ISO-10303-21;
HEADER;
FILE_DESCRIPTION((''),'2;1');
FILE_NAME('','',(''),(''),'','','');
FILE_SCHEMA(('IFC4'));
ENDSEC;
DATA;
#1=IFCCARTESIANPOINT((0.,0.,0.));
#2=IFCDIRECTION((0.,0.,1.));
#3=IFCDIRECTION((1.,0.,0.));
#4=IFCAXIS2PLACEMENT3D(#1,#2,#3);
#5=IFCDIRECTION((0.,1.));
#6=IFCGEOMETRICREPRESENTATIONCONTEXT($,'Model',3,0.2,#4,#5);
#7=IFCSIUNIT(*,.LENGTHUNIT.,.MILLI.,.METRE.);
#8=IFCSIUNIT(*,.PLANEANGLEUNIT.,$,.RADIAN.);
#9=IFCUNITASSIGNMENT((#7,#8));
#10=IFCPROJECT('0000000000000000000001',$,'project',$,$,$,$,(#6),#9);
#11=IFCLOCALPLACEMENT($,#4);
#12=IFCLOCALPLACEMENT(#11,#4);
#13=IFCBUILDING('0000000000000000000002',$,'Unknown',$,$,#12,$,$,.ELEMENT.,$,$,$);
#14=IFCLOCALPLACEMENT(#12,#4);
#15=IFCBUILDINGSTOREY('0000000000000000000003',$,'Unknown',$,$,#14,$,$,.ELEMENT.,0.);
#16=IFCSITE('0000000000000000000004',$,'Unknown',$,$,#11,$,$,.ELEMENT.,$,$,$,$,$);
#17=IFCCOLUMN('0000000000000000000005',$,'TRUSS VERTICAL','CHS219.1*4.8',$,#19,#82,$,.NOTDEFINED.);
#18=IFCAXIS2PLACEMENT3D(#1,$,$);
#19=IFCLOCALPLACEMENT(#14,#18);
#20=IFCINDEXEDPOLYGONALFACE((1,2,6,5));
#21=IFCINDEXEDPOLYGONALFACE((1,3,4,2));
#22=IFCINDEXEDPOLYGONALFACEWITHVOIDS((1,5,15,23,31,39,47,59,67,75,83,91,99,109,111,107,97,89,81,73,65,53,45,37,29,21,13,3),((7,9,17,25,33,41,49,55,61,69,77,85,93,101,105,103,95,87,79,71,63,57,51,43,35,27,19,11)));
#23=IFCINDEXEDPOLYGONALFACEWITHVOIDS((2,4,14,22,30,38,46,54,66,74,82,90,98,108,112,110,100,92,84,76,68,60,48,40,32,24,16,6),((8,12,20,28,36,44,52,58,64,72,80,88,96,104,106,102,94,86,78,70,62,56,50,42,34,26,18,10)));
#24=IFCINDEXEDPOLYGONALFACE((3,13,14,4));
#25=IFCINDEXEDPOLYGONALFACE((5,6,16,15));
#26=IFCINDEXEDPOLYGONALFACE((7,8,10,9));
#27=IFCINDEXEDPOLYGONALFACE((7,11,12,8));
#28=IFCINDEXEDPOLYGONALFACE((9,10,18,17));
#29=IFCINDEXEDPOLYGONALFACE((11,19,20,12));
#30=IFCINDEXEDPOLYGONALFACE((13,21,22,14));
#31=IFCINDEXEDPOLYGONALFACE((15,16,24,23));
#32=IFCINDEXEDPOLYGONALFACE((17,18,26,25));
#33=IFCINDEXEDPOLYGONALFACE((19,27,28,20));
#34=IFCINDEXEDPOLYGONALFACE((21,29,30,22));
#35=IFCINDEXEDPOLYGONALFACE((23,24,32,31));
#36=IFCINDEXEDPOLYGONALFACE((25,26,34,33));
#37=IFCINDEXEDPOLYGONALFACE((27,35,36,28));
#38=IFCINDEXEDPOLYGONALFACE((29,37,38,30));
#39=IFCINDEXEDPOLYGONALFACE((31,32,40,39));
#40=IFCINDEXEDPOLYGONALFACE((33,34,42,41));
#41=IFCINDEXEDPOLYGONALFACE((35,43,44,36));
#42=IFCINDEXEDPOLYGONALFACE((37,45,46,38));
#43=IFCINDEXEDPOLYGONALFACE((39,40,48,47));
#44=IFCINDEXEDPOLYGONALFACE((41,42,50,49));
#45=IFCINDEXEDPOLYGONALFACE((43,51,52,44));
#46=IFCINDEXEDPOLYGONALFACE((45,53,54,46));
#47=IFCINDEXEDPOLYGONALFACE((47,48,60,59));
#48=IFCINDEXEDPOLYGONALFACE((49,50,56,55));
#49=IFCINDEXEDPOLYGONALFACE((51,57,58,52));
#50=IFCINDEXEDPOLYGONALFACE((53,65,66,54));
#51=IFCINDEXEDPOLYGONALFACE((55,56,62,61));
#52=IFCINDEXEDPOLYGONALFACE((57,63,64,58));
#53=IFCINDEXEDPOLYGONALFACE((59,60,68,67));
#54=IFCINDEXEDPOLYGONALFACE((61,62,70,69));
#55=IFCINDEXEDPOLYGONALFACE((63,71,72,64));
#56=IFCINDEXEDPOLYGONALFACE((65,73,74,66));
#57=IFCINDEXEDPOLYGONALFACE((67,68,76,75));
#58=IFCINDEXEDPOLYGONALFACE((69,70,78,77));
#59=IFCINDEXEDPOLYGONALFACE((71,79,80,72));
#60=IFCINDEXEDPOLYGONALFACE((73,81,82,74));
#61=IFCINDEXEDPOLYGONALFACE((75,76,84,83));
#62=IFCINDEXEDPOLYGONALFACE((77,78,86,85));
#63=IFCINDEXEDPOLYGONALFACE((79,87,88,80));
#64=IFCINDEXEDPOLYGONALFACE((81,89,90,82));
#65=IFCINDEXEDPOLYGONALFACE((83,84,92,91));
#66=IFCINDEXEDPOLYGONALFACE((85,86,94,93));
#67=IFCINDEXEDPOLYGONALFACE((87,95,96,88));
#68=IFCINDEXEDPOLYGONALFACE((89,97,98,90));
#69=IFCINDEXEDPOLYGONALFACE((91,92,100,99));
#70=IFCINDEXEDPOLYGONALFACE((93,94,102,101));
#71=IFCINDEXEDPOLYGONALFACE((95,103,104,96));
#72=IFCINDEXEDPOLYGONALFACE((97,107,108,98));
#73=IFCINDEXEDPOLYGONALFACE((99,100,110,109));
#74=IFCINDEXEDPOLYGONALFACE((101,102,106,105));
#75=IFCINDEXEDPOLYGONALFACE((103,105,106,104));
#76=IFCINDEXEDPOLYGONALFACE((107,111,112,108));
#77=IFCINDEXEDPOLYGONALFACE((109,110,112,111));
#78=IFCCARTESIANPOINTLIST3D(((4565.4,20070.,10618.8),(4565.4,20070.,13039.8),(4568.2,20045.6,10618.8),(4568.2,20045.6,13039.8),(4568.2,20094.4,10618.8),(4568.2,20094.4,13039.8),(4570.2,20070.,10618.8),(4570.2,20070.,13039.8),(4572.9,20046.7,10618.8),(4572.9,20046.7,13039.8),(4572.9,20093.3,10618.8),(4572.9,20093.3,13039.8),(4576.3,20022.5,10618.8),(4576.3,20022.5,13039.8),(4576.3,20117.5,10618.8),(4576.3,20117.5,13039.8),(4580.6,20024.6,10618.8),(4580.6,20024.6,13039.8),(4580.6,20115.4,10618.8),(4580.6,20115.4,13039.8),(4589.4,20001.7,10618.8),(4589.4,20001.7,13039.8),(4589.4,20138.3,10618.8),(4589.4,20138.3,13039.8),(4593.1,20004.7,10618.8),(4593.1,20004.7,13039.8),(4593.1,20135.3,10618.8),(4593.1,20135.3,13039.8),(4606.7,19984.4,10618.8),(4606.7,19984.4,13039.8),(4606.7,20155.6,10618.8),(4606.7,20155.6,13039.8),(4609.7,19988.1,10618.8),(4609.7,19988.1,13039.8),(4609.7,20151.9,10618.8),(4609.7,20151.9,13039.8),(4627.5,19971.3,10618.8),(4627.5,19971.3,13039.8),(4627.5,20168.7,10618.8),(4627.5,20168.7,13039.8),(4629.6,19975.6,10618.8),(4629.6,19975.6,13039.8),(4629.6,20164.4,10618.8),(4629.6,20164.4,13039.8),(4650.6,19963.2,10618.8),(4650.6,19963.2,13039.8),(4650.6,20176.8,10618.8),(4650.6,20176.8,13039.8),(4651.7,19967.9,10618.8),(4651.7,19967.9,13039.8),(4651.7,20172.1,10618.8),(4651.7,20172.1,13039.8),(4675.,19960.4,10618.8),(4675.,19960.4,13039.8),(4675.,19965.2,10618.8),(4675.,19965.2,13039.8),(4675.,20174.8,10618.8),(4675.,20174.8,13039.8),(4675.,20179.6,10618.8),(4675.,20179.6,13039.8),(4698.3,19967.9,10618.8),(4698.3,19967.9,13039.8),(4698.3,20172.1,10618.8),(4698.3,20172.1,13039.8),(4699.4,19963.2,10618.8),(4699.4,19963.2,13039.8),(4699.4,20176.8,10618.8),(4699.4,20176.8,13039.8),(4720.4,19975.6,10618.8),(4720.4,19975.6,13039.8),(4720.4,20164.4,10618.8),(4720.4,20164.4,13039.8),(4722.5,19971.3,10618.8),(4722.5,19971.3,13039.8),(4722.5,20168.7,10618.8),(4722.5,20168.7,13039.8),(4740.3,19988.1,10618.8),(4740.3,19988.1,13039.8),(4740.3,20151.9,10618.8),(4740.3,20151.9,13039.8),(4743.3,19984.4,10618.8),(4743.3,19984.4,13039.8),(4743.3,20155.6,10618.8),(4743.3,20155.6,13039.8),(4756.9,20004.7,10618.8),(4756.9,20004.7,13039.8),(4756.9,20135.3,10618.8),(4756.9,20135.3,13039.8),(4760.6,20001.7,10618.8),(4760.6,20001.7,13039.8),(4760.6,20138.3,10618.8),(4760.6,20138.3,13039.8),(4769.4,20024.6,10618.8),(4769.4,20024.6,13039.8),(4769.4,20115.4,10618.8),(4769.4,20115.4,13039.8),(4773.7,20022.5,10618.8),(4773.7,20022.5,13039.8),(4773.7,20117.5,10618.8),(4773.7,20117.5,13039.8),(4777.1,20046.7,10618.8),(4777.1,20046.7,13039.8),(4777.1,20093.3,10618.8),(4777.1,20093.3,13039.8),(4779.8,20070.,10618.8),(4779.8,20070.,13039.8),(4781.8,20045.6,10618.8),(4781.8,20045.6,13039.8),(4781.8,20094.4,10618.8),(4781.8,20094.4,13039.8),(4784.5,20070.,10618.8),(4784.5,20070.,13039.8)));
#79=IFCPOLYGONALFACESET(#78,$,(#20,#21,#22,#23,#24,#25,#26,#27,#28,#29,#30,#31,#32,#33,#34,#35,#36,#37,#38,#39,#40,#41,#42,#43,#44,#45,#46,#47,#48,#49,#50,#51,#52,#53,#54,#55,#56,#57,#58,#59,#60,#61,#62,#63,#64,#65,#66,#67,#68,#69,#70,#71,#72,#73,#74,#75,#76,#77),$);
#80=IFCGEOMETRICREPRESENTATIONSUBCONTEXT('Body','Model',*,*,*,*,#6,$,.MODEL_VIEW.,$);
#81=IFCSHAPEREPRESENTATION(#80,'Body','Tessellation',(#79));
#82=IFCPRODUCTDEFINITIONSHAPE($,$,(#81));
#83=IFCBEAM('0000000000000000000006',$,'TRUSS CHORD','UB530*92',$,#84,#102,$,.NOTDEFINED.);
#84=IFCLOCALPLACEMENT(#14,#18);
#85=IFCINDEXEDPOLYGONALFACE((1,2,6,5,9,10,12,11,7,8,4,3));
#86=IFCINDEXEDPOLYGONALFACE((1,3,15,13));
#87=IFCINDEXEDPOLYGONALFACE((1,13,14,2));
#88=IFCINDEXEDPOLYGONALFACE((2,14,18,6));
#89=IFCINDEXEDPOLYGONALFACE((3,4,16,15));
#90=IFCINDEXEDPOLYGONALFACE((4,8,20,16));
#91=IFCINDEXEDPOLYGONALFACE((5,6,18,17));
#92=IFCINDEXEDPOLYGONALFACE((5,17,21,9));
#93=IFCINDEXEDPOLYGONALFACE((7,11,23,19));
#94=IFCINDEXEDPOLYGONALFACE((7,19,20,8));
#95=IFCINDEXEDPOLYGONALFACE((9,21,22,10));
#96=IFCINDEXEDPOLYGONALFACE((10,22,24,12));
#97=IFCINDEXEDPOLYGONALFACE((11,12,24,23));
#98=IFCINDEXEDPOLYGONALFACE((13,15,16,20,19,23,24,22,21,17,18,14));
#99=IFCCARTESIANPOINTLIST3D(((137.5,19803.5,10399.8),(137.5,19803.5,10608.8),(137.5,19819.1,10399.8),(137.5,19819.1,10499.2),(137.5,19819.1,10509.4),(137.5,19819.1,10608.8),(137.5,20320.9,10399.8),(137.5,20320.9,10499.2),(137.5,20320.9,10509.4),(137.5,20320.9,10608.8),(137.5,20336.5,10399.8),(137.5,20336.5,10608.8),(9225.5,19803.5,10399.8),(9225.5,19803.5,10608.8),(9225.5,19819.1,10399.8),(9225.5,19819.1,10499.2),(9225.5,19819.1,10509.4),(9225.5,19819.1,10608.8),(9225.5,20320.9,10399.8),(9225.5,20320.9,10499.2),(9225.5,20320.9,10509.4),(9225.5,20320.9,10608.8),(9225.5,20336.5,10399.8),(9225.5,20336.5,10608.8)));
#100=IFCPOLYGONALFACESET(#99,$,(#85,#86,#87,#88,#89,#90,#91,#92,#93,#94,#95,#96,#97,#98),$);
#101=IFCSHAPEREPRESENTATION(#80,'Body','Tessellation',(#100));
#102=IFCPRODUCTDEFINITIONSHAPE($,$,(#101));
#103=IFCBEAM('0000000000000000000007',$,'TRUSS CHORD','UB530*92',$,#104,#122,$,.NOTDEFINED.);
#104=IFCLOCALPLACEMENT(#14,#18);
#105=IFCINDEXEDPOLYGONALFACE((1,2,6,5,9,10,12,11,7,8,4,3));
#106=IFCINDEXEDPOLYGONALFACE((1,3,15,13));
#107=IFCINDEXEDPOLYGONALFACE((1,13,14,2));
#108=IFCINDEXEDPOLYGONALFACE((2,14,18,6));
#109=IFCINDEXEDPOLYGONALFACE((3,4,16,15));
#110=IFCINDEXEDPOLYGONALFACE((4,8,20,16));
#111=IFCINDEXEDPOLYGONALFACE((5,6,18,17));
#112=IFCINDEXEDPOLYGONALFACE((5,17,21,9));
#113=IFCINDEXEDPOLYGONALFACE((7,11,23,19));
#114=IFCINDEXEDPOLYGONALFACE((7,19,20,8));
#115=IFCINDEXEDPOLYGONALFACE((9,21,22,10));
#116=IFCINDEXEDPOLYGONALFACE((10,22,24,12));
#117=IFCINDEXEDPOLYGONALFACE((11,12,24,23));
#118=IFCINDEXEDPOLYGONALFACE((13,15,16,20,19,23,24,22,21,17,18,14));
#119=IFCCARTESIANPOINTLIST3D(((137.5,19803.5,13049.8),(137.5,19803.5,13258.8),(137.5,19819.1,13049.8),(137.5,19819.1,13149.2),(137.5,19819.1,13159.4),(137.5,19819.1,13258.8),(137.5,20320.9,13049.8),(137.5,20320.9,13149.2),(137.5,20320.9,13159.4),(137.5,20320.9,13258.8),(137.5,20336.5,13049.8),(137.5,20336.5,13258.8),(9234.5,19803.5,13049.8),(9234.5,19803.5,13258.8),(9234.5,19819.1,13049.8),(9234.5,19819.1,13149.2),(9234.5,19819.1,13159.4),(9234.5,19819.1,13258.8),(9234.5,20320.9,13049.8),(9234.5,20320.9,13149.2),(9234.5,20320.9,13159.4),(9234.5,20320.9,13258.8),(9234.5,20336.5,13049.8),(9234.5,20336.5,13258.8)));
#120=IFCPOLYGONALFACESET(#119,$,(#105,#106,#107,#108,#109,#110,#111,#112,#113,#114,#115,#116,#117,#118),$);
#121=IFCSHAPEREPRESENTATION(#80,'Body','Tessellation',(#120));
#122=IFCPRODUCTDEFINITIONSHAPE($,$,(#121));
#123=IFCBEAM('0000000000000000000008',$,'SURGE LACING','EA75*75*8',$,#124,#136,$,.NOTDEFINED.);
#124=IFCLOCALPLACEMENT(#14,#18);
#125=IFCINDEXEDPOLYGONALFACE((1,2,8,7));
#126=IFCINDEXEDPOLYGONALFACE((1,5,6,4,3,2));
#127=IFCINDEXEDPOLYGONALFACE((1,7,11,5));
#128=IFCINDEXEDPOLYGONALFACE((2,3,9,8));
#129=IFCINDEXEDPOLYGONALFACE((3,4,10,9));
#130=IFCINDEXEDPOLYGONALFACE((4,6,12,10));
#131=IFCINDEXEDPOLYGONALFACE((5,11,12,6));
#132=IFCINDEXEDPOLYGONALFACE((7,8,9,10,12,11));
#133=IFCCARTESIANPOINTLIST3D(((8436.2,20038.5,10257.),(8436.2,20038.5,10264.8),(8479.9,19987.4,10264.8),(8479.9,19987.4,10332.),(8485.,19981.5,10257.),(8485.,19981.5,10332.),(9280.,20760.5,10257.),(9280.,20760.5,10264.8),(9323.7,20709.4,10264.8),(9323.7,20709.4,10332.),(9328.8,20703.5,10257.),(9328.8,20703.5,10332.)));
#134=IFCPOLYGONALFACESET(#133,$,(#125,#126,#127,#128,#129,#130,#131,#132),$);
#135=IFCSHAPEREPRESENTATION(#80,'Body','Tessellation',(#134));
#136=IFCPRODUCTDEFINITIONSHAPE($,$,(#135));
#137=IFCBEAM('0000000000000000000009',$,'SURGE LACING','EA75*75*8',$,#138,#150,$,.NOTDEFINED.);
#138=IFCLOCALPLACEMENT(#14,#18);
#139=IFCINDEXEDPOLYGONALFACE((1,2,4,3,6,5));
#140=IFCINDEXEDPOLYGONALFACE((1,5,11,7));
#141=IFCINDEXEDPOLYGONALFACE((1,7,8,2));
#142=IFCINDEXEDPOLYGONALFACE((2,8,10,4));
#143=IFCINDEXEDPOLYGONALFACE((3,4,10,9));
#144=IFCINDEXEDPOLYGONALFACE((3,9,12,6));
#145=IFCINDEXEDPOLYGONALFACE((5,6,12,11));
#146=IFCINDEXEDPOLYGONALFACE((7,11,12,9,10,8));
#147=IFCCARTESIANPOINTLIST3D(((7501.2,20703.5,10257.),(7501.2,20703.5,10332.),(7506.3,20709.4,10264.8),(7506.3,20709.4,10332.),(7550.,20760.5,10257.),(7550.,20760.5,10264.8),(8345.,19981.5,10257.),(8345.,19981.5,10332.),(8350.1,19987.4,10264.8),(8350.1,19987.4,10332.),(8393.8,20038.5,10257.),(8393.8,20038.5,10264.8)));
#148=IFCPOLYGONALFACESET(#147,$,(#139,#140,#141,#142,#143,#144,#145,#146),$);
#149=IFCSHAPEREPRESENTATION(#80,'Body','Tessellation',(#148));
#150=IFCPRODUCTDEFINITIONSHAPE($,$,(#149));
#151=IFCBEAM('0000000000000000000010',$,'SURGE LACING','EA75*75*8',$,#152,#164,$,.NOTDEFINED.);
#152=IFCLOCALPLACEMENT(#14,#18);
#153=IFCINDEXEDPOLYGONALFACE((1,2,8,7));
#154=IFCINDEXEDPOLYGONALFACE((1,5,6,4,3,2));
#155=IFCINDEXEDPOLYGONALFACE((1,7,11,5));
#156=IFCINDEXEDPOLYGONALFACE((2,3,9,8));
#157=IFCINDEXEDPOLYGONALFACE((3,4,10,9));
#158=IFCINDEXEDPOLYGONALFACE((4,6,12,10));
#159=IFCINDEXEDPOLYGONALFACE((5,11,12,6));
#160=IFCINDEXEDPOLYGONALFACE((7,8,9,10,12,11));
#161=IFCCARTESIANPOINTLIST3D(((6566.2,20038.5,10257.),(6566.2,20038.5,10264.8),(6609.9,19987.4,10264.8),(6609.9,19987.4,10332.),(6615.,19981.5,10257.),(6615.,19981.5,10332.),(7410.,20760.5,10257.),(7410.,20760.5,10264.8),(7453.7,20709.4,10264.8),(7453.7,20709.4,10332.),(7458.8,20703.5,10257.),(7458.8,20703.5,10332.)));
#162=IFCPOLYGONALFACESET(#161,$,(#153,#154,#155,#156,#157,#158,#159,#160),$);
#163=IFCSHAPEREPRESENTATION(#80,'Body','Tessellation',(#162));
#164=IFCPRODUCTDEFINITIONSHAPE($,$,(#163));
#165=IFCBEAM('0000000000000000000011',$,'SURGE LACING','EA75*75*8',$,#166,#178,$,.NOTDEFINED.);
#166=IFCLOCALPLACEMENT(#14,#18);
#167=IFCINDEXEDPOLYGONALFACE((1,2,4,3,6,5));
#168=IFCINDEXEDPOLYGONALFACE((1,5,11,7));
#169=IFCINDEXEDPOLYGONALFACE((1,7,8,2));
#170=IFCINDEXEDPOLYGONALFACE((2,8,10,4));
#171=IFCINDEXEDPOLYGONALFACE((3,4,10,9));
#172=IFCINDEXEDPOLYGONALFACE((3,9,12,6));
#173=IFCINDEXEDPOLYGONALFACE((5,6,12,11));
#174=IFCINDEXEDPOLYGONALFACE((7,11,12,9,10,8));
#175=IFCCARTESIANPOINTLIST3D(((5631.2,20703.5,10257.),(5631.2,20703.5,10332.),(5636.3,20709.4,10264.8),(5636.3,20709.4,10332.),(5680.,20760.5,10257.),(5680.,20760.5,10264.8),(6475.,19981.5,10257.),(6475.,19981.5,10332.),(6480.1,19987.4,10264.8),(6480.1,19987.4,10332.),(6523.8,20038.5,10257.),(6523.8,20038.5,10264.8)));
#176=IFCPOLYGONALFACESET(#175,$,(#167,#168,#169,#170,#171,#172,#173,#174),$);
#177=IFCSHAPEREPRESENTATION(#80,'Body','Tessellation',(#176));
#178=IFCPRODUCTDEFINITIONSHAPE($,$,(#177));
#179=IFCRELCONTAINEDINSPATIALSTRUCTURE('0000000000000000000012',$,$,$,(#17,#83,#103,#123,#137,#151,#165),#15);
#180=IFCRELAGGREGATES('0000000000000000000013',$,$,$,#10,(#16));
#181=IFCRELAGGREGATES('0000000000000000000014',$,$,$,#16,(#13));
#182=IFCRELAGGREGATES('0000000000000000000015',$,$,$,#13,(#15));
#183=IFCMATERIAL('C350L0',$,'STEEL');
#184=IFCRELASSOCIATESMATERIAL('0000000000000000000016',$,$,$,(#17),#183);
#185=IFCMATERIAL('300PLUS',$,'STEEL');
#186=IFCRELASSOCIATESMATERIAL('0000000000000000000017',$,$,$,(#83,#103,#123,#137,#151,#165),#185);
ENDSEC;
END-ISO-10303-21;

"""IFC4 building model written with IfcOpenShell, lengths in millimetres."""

from ifc_helpers import new_model, si_unit, direction, frame, origin_with_axes, place, context, subcontext, project, spatial, line, indexed_curve, outline, extrude, material, element, save


model = new_model("IFC4")

# Units and contexts
model_context = context("Model", 3, precision=0.2, world=origin_with_axes(), true_north=direction((0.0, 1.0)))
body_context = subcontext(model_context, "Body", "Model", "MODEL_VIEW")
ifc_project = project(units=[si_unit("LENGTHUNIT", "METRE", prefix="MILLI"), si_unit("PLANEANGLEUNIT", "RADIAN")], contexts=[model_context])

# Site, building, storey
site_placement = place(None, origin_with_axes())
site = spatial("IfcSite", under=ifc_project, at=site_placement, Name="Unknown", CompositionType="ELEMENT")
building_placement = place(site_placement, origin_with_axes())
building = spatial("IfcBuilding", under=site, at=building_placement, Name="Unknown", CompositionType="ELEMENT")
storey_placement = place(building_placement, origin_with_axes())
storey = spatial("IfcBuildingStorey", under=building, at=storey_placement, Name="Unknown", CompositionType="ELEMENT", Elevation=0.0)

# Column
ifc_material_1 = material(Name="C350L0", Category="STEEL")
column_placement = place(storey_placement, frame((4675.0, 20070.0, 10618.8), z_axis=(-1.0, 0.0, 0.0), x_axis=(0.0, 0.0, 1.0)))
element("IfcColumn", 1, at=column_placement, inside=storey, material=ifc_material_1, Name="TRUSS VERTICAL", Description="CHS219.1*4.8", PredefinedType="NOTDEFINED", context=body_context, shape_type="SolidModel", body=[
    extrude(outline(indexed_curve([(109.5, 0.0), (106.8, 24.4), (98.7, 47.5), (85.6, 68.3), (68.3, 85.6), (47.5, 98.7), (24.4, 106.8), (0.0, 109.5), (-24.4, 106.8), (-47.5, 98.7), (-68.3, 85.6), (-85.6, 68.3), (-98.7, 47.5), (-106.8, 24.4), (-109.5, 0.0), (-106.8, -24.4), (-98.7, -47.5), (-85.6, -68.3), (-68.3, -85.6), (-47.5, -98.7), (-24.4, -106.8), (0.0, -109.5), (24.4, -106.8), (47.5, -98.7), (68.3, -85.6), (85.6, -68.3), (98.7, -47.5), (106.8, -24.4)], segments=[line(1, 2, 3, 4, 5, 6, 7, 8, 9, 10, 11, 12, 13, 14, 15, 16, 17, 18, 19, 20, 21, 22, 23, 24, 25, 26, 27, 28, 1)]), holes=[indexed_curve([(104.8, 0.0), (102.1, -23.3), (94.4, -45.4), (81.9, -65.3), (65.3, -81.9), (45.4, -94.4), (23.3, -102.1), (0.0, -104.8), (-23.3, -102.1), (-45.4, -94.4), (-65.3, -81.9), (-81.9, -65.3), (-94.4, -45.4), (-102.1, -23.3), (-104.8, 0.0), (-102.1, 23.3), (-94.4, 45.4), (-81.9, 65.3), (-65.3, 81.9), (-45.4, 94.4), (-23.3, 102.1), (0.0, 104.8), (23.3, 102.1), (45.4, 94.4), (65.3, 81.9), (81.9, 65.3), (94.4, 45.4), (102.1, 23.3)], segments=[line(1, 2, 3, 4, 5, 6, 7, 8, 9, 10, 11, 12, 13, 14, 15, 16, 17, 18, 19, 20, 21, 22, 23, 24, 25, 26, 27, 28, 1)])]), frame((0.0, 0.0, 0.0), z_axis=(-1.0, 0.0, 0.0), x_axis=(0.0, 0.0, 1.0)), (0.0, 0.0, -1.0), 2421.0),
])

# Beams
ifc_material_2 = material(Name="300PLUS", Category="STEEL")
beam_1_placement = place(storey_placement, frame((137.5, 20070.0, 10504.3), z_axis=(0.0, 0.0, 1.0), x_axis=(1.0, 0.0, 0.0)))
element("IfcBeam", 2, at=beam_1_placement, inside=storey, material=ifc_material_2, Name="TRUSS CHORD", Description="UB530*92", PredefinedType="NOTDEFINED", context=body_context, shape_type="SolidModel", body=[
    extrude(outline(indexed_curve([(-104.5, -266.5), (104.5, -266.5), (104.5, -250.9), (5.1, -250.9), (5.1, 250.9), (104.5, 250.9), (104.5, 266.5), (-104.5, 266.5), (-104.5, 250.9), (-5.1, 250.9), (-5.1, -250.9), (-104.5, -250.9)], segments=[line(1, 2, 3, 4, 5, 6, 7, 8, 9, 10, 11, 12, 1)])), frame((0.0, 0.0, 0.0), z_axis=(-1.0, 0.0, 0.0), x_axis=(0.0, 0.0, 1.0)), (0.0, 0.0, -1.0), 9088.0),
])
beam_2_placement = place(storey_placement, frame((137.5, 20070.0, 13154.3), z_axis=(0.0, 0.0, 1.0), x_axis=(1.0, 0.0, 0.0)))
element("IfcBeam", 3, at=beam_2_placement, inside=storey, material=ifc_material_2, Name="TRUSS CHORD", Description="UB530*92", PredefinedType="NOTDEFINED", context=body_context, shape_type="SolidModel", body=[
    extrude(outline(indexed_curve([(-104.5, -266.5), (104.5, -266.5), (104.5, -250.9), (5.1, -250.9), (5.1, 250.9), (104.5, 250.9), (104.5, 266.5), (-104.5, 266.5), (-104.5, 250.9), (-5.1, 250.9), (-5.1, -250.9), (-104.5, -250.9)], segments=[line(1, 2, 3, 4, 5, 6, 7, 8, 9, 10, 11, 12, 1)])), frame((0.0, 0.0, 0.0), z_axis=(-1.0, 0.0, 0.0), x_axis=(0.0, 0.0, 1.0)), (0.0, 0.0, -1.0), 9097.0),
])
for number, where, z_axis, x_axis, name in (
    (4, (8460.6, 20010.0, 10294.5), (0.0, 0.0, 1.0), (0.759816, 0.650139, 0.0), "SURGE LACING"),
    (5, (7525.6, 20732.0, 10294.5), (0.0, 0.0, 1.0), (0.759816, -0.650139, 0.0), "SURGE LACING"),
    (6, (6590.6, 20010.0, 10294.5), (0.0, 0.0, 1.0), (0.759816, 0.650139, 0.0), "SURGE LACING"),
    (7, (5655.6, 20732.0, 10294.5), (0.0, 0.0, 1.0), (0.759816, -0.650139, 0.0), "SURGE LACING"),
):
    element("IfcBeam", number, at=place(storey_placement, frame(where, z_axis=z_axis, x_axis=x_axis)), inside=storey, material=ifc_material_2, Name=name, Description="EA75*75*8", PredefinedType="NOTDEFINED", context=body_context, shape_type="SolidModel", body=[
        extrude(outline(indexed_curve([(-37.5, -37.5), (37.5, -37.5), (37.5, -29.7), (-29.7, -29.7), (-29.7, 37.5), (-37.5, 37.5)], segments=[line(1, 2, 3, 4, 5, 6, 1)])), frame((0.0, 0.0, 0.0), z_axis=(-1.0, 0.0, 0.0), x_axis=(0.0, 0.0, 1.0)), (0.0, 0.0, -1.0), 1110.5),
    ])

save(model, "model.ifc")
